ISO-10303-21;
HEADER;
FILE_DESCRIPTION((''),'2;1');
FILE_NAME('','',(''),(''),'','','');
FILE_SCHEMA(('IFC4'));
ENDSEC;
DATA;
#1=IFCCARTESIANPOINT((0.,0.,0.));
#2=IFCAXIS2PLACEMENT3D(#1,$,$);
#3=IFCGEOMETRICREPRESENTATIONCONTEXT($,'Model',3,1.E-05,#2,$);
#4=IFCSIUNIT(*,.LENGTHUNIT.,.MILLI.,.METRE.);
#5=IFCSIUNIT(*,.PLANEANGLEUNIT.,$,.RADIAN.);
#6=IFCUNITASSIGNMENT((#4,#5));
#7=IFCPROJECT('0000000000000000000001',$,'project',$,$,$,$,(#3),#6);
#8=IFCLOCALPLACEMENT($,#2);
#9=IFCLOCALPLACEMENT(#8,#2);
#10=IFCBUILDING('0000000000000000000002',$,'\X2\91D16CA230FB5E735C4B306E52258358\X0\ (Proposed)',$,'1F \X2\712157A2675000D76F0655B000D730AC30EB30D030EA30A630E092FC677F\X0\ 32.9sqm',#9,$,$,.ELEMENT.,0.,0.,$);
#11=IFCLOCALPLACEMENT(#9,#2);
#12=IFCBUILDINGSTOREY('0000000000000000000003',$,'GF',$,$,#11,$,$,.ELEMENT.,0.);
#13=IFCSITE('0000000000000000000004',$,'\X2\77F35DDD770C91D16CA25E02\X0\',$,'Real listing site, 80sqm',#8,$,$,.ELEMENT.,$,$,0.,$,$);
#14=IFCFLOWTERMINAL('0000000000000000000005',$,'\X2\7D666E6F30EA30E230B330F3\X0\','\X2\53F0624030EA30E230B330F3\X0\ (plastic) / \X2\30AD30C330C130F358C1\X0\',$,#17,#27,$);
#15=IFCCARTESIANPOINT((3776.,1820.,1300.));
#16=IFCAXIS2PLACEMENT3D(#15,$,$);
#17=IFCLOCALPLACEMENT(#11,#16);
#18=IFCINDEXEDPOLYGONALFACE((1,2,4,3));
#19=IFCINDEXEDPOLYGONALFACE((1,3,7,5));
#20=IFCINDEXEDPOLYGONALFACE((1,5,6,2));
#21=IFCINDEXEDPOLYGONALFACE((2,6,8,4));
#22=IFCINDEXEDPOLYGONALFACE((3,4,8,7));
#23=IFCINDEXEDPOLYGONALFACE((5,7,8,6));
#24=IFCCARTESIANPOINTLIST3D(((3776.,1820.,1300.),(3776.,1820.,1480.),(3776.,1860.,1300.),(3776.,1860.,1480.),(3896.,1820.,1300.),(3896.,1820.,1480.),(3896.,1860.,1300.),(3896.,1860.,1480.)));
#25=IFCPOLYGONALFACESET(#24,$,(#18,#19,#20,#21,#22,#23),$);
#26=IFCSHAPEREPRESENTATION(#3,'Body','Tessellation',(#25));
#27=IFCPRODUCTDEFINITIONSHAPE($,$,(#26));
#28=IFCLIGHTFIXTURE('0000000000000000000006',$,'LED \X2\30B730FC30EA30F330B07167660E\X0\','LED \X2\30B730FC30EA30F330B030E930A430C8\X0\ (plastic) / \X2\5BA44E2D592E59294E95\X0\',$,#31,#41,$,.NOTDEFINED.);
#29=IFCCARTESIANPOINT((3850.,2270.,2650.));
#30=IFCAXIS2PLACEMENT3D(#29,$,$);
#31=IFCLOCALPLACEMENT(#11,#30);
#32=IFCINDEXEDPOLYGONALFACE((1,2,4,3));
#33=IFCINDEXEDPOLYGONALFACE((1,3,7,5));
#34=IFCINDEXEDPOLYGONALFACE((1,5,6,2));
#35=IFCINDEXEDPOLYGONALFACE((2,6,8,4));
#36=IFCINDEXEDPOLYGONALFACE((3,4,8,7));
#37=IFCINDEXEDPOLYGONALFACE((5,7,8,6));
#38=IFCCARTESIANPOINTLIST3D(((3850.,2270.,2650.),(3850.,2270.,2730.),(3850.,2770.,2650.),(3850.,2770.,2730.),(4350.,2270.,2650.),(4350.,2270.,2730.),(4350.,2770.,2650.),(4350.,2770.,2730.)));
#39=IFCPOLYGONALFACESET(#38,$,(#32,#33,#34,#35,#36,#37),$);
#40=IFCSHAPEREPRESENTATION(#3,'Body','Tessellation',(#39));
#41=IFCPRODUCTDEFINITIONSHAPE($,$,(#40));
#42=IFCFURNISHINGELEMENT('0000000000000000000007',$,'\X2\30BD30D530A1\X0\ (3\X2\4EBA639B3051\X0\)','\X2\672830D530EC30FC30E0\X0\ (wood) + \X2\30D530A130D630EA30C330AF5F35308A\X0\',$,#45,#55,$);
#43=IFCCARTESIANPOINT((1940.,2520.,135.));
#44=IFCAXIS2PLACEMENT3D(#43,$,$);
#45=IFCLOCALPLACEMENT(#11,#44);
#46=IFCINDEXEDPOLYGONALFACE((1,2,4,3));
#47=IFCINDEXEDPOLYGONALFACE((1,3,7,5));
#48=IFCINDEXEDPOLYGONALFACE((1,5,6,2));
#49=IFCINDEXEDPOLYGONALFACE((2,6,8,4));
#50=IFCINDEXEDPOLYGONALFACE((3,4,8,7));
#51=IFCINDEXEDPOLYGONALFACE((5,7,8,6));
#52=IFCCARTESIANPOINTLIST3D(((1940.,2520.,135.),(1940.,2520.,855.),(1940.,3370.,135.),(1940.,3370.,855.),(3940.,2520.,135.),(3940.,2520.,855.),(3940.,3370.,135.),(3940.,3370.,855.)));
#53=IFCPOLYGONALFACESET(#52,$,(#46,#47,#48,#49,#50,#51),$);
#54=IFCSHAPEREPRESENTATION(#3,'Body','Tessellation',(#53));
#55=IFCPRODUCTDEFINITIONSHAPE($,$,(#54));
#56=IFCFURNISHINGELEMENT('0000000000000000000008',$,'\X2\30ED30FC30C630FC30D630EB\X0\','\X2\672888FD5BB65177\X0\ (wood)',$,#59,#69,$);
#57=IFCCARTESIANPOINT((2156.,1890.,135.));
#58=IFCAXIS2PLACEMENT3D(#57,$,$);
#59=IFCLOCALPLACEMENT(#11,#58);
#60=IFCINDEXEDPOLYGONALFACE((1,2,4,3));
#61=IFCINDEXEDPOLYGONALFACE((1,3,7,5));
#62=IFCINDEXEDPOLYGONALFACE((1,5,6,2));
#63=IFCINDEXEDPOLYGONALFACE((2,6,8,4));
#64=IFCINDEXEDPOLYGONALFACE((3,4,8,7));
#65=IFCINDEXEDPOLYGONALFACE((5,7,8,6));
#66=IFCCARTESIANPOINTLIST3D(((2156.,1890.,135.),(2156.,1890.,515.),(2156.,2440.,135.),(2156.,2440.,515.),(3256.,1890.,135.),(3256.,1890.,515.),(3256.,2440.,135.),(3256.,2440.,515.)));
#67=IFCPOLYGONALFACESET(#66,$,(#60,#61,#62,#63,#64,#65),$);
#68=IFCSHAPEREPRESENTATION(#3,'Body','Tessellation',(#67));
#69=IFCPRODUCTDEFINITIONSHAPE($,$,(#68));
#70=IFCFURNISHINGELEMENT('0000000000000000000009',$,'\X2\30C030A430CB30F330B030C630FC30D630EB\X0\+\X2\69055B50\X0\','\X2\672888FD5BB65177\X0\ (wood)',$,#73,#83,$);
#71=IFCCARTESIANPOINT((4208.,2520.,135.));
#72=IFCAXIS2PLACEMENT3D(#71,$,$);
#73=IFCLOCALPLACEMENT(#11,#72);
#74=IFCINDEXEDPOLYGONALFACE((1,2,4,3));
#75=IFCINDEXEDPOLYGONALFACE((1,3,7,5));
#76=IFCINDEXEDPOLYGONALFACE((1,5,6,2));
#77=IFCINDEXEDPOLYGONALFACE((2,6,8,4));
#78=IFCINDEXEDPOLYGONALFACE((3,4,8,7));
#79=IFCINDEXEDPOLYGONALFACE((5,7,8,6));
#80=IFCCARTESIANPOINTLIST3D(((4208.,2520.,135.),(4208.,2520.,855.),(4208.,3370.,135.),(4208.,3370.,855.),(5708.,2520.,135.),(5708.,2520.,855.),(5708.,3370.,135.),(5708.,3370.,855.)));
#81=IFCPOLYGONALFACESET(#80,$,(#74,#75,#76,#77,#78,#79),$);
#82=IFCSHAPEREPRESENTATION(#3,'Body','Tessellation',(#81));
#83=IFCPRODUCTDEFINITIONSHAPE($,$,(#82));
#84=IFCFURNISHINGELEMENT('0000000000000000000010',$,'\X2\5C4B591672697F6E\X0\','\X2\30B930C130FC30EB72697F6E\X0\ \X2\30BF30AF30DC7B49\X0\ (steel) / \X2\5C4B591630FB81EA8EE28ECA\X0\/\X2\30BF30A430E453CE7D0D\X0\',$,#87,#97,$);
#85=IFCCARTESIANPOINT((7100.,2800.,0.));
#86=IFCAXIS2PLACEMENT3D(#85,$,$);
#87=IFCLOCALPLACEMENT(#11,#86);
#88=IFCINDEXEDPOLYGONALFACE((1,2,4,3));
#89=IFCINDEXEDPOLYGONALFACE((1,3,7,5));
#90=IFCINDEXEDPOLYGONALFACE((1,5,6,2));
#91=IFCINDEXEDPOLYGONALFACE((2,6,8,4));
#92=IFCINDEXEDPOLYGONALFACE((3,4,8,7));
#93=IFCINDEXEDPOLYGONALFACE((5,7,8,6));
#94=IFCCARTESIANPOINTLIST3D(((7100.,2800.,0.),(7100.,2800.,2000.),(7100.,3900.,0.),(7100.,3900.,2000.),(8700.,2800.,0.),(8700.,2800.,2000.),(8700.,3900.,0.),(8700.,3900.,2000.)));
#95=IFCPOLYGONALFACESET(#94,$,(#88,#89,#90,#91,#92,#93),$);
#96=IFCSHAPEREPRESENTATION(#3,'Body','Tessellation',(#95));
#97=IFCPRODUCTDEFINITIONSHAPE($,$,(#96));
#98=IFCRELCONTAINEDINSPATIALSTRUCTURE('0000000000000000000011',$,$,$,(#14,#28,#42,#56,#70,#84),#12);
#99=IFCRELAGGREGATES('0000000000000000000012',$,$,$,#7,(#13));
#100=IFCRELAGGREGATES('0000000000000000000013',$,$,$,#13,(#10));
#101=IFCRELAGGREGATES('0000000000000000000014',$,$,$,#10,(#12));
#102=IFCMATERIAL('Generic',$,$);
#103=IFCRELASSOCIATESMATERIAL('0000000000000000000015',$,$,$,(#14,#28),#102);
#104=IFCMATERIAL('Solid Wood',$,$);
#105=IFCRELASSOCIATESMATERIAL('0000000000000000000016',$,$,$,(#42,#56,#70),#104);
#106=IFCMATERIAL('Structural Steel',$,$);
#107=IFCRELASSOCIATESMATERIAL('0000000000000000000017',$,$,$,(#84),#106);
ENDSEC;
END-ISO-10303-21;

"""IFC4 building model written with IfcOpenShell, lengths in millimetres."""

from ifc_helpers import new_model, si_unit, frame, frame_2d, origin, place, context, project, spatial, rectangle, extrude, material, element, save


model = new_model("IFC4")

# Units and contexts
model_context = context("Model", 3, precision=1e-05, world=origin())
ifc_project = project(units=[si_unit("LENGTHUNIT", "METRE", prefix="MILLI"), si_unit("PLANEANGLEUNIT", "RADIAN")], contexts=[model_context])

# Site, building, storey
site_placement = place(None, origin())
site = spatial("IfcSite", under=ifc_project, at=site_placement, Name="石川県金沢市", ObjectType="Real listing site, 80sqm", CompositionType="ELEMENT", RefElevation=0.0)
building_placement = place(site_placement, origin())
building = spatial("IfcBuilding", under=site, at=building_placement, Name="金沢・平屋の別荘 (Proposed)", ObjectType="1F 無垢材×漆喰×ガルバリウム鋼板 32.9sqm", CompositionType="ELEMENT", ElevationOfRefHeight=0.0, ElevationOfTerrain=0.0)
storey_placement = place(building_placement, origin())
storey = spatial("IfcBuildingStorey", under=building, at=storey_placement, Name="GF", CompositionType="ELEMENT", Elevation=0.0)

# Shared definitions
ifc_material_1 = material(Name="Solid Wood")

# Shared definitions
ifc_material_2 = material(Name="Structural Steel")

# Flow terminal
ifc_material_3 = material(Name="Generic")
flow_terminal_placement = place(storey_placement, frame((3776.0, 1820.0, 1300.0)))
element("IfcFlowTerminal", 1, at=flow_terminal_placement, inside=storey, material=ifc_material_3, Name="給湯リモコン", Description="台所リモコン (plastic) / キッチン壁", context=model_context, shape_type="SweptSolid", body=[
    extrude(rectangle(XDim=120.0, YDim=40.0, at=frame_2d((60.0, 20.0))), frame((3776.0, 1820.0, 1300.0)), (0.0, 0.0, 1.0), 180.0),
])

# Light fixture
light_fixture_placement = place(storey_placement, frame((3850.0, 2270.0, 2650.0)))
element("IfcLightFixture", 2, at=light_fixture_placement, inside=storey, material=ifc_material_3, Name="LED シーリング照明", Description="LED シーリングライト (plastic) / 室中央天井", PredefinedType="NOTDEFINED", context=model_context, shape_type="SweptSolid", body=[
    extrude(rectangle(XDim=500.0, YDim=500.0, at=frame_2d((250.0, 250.0))), frame((3850.0, 2270.0, 2650.0)), (0.0, 0.0, 1.0), 80.0),
])

# Furnishing elements
furnishing_1_placement = place(storey_placement, frame((1940.0, 2520.0, 135.0)))
element("IfcFurnishingElement", 3, at=furnishing_1_placement, inside=storey, material=ifc_material_1, Name="ソファ (3人掛け)", Description="木フレーム (wood) + ファブリック張り", context=model_context, shape_type="SweptSolid", body=[
    extrude(rectangle(XDim=2000.0, YDim=850.0, at=frame_2d((1000.0, 425.0))), frame((1940.0, 2520.0, 135.0)), (0.0, 0.0, 1.0), 720.0),
])
furnishing_2_placement = place(storey_placement, frame((2156.0, 1890.0, 135.0)))
element("IfcFurnishingElement", 4, at=furnishing_2_placement, inside=storey, material=ifc_material_1, Name="ローテーブル", Description="木製家具 (wood)", context=model_context, shape_type="SweptSolid", body=[
    extrude(rectangle(XDim=1100.0, YDim=550.0, at=frame_2d((550.0, 275.0))), frame((2156.0, 1890.0, 135.0)), (0.0, 0.0, 1.0), 380.0),
])
furnishing_3_placement = place(storey_placement, frame((4208.0, 2520.0, 135.0)))
element("IfcFurnishingElement", 5, at=furnishing_3_placement, inside=storey, material=ifc_material_1, Name="ダイニングテーブル+椅子", Description="木製家具 (wood)", context=model_context, shape_type="SweptSolid", body=[
    extrude(rectangle(XDim=1500.0, YDim=850.0, at=frame_2d((750.0, 425.0))), frame((4208.0, 2520.0, 135.0)), (0.0, 0.0, 1.0), 720.0),
])
furnishing_4_placement = place(storey_placement, frame((7100.0, 2800.0, 0.0)))
element("IfcFurnishingElement", 6, at=furnishing_4_placement, inside=storey, material=ifc_material_2, Name="屋外物置", Description="スチール物置 タクボ等 (steel) / 屋外・自転車/タイヤ収納", context=model_context, shape_type="SweptSolid", body=[
    extrude(rectangle(XDim=1600.0, YDim=1100.0, at=frame_2d((800.0, 550.0))), frame((7100.0, 2800.0, 0.0)), (0.0, 0.0, 1.0), 2000.0),
])

save(model, "model.ifc")
